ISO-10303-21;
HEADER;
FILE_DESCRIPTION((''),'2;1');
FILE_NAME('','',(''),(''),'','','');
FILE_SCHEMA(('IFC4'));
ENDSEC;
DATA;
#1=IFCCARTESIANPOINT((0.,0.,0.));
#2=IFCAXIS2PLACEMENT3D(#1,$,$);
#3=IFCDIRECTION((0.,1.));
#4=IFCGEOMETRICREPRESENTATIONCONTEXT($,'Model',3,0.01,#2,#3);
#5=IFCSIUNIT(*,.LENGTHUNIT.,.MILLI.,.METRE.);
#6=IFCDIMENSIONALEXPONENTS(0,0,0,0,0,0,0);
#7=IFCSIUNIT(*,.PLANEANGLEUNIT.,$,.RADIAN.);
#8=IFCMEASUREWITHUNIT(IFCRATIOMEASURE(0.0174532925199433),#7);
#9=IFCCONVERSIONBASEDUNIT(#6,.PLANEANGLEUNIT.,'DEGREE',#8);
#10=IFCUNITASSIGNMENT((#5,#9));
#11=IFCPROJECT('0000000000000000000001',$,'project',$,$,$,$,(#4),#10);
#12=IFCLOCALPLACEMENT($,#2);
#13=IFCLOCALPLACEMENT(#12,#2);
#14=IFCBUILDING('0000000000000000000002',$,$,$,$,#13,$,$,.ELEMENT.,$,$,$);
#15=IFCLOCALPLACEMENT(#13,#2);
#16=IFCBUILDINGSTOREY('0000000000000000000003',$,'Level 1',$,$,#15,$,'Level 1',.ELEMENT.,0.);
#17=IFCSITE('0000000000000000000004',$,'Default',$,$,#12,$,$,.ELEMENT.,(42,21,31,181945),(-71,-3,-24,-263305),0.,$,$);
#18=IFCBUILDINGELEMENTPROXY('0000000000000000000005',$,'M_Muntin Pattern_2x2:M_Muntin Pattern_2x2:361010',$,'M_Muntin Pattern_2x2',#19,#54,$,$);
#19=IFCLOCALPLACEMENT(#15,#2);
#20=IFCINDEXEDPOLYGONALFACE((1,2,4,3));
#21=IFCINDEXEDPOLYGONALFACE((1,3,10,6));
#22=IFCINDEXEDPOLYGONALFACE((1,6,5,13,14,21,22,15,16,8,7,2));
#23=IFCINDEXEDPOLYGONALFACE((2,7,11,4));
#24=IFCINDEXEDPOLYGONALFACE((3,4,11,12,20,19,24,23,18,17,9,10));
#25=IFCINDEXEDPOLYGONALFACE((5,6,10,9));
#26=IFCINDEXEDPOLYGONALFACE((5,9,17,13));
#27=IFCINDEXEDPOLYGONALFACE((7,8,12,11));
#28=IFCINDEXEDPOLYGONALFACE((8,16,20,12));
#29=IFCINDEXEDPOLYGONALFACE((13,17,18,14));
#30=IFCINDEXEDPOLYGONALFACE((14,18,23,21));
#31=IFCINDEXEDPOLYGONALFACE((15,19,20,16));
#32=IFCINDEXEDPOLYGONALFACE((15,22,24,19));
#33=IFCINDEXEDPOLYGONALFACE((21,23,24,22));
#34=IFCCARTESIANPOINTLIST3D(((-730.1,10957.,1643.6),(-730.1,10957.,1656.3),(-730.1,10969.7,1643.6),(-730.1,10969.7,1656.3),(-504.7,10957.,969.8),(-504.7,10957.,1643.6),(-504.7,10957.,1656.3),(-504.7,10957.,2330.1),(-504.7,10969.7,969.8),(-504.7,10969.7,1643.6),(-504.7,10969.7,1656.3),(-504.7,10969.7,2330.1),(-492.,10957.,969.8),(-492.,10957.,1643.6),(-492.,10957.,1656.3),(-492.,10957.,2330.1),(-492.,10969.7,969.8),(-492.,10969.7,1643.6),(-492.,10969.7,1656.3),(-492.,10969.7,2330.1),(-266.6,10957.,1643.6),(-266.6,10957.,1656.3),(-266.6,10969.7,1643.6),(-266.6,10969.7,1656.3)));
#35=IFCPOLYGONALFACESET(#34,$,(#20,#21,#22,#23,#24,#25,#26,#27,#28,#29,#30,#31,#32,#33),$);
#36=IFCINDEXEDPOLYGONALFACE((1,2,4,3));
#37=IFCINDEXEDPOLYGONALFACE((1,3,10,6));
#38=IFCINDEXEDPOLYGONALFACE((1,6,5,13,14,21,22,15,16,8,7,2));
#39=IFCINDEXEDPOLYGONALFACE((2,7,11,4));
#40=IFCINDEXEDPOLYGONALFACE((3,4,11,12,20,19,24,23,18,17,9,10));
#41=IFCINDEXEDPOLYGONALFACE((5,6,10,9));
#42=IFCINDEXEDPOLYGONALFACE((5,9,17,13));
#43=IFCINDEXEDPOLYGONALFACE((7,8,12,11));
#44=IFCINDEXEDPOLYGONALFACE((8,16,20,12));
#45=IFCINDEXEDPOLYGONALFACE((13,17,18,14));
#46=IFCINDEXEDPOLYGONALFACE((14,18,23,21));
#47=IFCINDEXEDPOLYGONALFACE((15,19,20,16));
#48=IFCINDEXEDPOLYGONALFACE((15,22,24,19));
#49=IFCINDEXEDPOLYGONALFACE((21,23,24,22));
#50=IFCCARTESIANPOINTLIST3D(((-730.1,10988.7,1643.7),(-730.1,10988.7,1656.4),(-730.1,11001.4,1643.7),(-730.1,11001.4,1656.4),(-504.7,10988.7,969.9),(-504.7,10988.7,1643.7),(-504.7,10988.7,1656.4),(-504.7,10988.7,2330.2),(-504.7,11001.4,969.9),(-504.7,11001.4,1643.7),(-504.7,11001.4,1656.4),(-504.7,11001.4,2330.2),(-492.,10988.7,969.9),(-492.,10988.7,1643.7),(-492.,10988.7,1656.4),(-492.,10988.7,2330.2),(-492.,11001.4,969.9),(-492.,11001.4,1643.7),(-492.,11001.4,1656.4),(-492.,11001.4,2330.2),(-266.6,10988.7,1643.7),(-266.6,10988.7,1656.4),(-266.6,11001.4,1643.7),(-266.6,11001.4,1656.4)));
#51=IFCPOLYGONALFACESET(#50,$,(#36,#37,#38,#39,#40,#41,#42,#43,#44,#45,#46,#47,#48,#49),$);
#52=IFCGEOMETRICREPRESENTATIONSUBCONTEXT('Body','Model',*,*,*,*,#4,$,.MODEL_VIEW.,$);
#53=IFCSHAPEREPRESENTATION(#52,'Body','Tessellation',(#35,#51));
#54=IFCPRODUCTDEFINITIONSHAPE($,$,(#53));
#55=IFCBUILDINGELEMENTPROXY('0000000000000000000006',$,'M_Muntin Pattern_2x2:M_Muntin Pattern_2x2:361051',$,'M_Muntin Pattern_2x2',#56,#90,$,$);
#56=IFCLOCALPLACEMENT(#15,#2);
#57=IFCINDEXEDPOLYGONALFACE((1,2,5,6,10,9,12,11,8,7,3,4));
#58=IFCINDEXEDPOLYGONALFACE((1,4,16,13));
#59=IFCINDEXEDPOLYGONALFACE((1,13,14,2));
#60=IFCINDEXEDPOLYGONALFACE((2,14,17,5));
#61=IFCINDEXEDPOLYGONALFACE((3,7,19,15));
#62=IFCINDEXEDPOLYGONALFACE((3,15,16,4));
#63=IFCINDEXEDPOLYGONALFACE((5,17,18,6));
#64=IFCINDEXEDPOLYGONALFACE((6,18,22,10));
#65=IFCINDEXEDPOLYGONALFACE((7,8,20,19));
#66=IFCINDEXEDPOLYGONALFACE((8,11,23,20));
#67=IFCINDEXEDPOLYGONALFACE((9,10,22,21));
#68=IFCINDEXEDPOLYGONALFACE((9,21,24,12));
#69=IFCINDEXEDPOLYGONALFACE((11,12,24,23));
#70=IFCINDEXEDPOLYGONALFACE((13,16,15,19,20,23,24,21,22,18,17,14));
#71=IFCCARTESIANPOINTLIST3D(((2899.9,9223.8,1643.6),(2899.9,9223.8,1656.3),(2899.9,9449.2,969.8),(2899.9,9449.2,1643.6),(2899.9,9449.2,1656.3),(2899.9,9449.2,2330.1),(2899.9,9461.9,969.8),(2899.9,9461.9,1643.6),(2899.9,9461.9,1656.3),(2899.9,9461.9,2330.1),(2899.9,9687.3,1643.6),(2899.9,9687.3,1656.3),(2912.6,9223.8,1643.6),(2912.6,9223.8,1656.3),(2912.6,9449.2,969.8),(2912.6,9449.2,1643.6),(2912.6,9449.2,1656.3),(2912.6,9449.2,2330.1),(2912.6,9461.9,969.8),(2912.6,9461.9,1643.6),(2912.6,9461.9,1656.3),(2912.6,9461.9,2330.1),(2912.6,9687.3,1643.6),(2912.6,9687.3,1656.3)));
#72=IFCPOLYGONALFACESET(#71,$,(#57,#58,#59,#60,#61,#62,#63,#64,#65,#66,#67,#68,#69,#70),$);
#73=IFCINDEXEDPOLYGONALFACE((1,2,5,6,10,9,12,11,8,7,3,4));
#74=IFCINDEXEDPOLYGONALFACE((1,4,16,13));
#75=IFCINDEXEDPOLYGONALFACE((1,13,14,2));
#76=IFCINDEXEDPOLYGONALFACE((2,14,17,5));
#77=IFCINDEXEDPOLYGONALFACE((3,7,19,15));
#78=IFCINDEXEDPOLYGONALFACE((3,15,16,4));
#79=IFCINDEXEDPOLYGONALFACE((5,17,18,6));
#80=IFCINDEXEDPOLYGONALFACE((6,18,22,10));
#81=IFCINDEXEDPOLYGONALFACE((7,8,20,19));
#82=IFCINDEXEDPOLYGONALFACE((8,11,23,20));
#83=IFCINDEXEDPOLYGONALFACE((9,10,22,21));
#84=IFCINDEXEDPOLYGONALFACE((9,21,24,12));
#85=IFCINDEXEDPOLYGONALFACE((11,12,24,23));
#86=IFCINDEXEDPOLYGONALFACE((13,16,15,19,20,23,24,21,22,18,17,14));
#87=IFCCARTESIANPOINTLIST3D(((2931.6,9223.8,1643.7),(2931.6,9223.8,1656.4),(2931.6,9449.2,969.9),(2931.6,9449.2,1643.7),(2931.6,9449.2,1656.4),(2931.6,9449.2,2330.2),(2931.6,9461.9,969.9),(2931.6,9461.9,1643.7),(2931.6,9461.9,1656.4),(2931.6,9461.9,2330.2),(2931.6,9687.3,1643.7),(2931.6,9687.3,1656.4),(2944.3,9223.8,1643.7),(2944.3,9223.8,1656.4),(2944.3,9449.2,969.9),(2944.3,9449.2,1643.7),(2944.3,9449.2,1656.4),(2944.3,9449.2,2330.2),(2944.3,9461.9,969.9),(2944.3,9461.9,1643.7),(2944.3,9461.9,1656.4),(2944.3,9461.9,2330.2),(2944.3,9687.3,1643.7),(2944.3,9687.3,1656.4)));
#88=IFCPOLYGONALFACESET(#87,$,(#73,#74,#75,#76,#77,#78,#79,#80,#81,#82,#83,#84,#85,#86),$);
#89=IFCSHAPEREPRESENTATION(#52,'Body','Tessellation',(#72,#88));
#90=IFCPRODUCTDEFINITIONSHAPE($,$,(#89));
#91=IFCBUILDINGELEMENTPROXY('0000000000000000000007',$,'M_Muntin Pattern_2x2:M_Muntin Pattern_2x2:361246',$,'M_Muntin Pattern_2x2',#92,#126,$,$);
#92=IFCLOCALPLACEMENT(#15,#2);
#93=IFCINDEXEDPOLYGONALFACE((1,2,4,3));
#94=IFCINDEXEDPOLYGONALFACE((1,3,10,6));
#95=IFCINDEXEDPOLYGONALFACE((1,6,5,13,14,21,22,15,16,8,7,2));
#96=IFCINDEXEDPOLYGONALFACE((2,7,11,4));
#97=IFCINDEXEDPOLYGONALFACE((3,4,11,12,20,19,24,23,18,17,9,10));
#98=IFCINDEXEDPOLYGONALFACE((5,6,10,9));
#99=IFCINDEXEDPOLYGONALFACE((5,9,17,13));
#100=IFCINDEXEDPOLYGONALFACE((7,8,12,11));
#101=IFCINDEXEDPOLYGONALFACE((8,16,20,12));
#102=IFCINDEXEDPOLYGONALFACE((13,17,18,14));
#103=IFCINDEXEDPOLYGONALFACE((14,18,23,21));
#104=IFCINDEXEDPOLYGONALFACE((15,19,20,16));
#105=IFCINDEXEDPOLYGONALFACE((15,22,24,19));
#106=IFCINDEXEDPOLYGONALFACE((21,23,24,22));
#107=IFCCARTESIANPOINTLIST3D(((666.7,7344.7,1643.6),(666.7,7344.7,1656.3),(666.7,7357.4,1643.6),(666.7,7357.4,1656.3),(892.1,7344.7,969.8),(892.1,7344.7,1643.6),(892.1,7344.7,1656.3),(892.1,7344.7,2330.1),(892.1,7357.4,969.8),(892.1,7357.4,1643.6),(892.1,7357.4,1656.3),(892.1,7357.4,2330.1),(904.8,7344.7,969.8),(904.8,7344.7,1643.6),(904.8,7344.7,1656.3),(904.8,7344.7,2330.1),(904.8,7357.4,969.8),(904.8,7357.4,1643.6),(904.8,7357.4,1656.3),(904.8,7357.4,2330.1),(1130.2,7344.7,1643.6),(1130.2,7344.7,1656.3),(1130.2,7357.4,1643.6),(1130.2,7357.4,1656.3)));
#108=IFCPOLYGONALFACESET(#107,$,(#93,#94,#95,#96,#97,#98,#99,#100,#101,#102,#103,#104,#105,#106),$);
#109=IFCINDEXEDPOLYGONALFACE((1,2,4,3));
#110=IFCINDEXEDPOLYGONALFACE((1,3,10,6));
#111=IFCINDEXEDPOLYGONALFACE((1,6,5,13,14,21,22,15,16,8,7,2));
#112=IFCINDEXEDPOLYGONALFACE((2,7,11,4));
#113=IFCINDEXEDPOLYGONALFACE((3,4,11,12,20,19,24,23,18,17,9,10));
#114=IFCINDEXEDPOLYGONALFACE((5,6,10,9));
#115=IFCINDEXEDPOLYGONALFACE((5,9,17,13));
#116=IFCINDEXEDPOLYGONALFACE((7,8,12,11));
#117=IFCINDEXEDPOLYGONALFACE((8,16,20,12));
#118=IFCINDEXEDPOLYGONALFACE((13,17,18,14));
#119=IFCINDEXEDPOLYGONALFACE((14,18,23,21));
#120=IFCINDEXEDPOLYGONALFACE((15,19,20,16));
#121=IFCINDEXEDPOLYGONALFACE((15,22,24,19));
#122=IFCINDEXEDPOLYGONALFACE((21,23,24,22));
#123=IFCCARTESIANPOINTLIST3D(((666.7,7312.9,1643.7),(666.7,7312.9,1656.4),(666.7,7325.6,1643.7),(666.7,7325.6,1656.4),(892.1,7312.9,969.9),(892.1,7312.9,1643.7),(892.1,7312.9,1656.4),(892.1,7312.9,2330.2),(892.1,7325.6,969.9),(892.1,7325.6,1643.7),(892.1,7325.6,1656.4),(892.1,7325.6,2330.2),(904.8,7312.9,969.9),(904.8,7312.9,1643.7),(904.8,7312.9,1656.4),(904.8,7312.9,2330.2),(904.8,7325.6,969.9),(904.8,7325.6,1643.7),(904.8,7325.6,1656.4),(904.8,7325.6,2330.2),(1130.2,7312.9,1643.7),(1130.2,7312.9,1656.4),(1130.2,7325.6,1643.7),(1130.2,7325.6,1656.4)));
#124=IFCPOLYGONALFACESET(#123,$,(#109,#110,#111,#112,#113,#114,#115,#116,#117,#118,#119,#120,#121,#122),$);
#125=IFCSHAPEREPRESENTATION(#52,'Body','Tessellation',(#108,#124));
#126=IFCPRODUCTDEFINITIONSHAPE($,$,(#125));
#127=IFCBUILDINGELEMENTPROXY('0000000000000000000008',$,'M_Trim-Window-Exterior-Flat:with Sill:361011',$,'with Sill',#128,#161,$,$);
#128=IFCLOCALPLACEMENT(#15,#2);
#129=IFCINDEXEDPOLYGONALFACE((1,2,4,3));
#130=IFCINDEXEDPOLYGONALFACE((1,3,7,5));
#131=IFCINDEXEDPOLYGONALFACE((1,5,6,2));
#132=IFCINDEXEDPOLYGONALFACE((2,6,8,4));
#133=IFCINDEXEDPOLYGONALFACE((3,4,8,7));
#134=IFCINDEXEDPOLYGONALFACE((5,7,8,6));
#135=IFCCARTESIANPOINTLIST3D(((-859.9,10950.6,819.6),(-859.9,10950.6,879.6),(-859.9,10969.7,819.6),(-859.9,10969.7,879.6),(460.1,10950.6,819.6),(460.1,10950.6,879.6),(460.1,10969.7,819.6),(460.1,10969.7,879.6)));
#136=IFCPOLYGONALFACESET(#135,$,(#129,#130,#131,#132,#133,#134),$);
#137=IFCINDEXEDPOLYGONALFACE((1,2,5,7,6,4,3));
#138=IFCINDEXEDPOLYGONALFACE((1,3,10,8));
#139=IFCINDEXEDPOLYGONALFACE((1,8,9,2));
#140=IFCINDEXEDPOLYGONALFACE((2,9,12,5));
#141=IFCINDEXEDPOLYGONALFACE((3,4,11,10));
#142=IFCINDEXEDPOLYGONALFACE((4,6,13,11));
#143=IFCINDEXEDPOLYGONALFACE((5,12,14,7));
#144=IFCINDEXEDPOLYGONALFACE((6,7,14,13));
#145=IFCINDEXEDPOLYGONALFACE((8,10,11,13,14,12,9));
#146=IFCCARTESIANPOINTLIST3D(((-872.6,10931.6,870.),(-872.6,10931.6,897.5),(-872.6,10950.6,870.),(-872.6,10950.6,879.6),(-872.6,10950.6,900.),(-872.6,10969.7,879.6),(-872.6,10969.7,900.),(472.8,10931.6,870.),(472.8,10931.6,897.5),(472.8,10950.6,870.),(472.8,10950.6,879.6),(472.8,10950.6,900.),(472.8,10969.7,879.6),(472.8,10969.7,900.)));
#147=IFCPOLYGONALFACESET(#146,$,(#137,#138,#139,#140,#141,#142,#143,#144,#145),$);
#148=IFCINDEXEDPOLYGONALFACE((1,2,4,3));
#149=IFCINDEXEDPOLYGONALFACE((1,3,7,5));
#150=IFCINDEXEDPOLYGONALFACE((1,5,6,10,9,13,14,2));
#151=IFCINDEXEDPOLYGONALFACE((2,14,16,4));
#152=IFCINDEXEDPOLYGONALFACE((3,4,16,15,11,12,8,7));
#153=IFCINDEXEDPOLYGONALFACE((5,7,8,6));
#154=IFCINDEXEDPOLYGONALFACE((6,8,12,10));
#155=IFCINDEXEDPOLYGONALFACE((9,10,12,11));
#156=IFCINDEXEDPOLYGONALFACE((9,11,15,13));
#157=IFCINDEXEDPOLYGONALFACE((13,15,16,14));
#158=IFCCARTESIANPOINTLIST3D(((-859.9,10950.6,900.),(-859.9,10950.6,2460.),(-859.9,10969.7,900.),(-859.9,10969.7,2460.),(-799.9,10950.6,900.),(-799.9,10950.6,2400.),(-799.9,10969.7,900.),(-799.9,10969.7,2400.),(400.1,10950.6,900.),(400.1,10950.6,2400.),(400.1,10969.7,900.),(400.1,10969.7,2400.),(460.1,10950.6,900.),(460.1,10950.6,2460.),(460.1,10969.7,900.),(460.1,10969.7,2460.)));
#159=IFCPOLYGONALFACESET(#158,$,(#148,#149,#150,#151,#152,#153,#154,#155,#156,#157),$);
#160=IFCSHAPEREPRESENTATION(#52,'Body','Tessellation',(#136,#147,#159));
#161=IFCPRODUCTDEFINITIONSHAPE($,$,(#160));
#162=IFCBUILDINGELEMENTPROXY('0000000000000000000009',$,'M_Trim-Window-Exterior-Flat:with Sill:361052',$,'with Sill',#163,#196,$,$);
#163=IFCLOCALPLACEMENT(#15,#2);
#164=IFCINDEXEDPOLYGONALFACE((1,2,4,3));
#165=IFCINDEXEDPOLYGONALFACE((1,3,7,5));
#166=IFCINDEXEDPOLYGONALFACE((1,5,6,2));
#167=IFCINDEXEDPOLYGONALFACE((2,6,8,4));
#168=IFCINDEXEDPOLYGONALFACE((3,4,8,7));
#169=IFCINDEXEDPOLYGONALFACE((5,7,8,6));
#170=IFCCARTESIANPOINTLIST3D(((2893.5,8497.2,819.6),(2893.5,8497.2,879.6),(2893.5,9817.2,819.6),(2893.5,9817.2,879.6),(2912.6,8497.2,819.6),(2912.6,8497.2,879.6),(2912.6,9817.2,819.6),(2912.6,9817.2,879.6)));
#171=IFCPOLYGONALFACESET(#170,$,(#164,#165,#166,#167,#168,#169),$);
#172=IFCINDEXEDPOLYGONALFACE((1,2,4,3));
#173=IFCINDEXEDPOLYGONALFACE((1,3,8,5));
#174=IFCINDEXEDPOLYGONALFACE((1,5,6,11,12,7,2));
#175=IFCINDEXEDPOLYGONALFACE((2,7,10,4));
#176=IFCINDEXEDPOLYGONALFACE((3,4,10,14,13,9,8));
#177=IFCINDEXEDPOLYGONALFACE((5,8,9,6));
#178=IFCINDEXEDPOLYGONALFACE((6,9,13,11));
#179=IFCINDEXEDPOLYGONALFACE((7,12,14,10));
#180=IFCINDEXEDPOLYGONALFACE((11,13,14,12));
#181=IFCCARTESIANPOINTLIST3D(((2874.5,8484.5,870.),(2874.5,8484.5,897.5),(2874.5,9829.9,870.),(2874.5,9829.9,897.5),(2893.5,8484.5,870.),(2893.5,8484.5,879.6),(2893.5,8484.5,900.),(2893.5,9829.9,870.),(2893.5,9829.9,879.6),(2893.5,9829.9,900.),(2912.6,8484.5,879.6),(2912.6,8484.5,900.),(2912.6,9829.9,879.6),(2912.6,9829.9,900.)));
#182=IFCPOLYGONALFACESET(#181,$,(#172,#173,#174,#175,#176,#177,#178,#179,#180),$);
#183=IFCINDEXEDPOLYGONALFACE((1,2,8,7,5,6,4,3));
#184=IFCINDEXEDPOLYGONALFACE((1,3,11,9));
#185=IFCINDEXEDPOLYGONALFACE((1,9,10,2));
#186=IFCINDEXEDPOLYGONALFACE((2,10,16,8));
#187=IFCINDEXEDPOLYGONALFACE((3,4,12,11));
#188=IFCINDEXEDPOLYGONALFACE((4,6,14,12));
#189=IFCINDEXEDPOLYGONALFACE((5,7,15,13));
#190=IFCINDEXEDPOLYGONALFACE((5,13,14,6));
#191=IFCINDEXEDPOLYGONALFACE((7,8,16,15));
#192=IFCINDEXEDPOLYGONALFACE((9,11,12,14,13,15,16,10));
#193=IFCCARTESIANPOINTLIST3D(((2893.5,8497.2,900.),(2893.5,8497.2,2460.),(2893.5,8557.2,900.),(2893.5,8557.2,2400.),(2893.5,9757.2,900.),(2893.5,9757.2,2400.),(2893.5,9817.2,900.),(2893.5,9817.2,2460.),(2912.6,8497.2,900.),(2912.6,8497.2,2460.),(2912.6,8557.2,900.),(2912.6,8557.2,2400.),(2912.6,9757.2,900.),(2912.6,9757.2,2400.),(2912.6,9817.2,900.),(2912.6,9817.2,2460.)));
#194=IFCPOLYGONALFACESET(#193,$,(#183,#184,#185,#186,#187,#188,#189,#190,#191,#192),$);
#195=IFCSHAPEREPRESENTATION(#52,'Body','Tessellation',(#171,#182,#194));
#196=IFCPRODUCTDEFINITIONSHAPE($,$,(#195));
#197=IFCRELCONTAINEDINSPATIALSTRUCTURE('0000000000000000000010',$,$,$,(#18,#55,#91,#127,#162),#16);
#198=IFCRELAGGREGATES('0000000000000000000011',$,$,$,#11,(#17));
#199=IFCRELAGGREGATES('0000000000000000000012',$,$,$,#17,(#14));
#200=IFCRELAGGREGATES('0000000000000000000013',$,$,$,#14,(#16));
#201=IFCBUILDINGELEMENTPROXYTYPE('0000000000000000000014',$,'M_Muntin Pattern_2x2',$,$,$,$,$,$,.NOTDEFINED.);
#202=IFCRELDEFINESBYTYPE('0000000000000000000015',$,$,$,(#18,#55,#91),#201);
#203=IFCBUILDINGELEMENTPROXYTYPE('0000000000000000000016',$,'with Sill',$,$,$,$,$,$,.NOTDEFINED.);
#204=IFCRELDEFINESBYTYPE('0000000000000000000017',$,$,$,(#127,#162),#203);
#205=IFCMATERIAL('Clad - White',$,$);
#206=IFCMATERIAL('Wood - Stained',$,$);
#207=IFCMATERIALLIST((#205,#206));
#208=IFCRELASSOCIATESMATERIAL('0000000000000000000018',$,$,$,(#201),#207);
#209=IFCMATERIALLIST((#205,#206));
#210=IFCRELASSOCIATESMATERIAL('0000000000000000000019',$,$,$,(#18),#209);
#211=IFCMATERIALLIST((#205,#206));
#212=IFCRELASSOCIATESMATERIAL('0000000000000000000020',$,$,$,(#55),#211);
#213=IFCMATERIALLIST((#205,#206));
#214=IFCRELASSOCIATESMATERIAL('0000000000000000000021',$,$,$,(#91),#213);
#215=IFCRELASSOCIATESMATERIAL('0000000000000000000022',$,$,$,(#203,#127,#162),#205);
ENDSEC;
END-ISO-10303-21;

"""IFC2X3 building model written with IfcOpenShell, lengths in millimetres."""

from ifc_helpers import new_model, entity, si_unit, converted_unit, direction, frame, frame_2d, origin, place, context, subcontext, project, spatial, polyline, rectangle, outline, extrude, source, transform, mapped, material, material_list, type_object, type_shapes, element, save


model = new_model("IFC2X3")

# Units and contexts
model_context = context("Model", 3, precision=0.01, world=origin(), true_north=direction((0.0, 1.0)))
body_context = subcontext(model_context, "Body", "Model", "MODEL_VIEW")
ifc_project = project(units=[si_unit("LENGTHUNIT", "METRE", prefix="MILLI"), converted_unit("PLANEANGLEUNIT", "DEGREE", entity("IfcRatioMeasure", 0.0174532925199433), si_unit("PLANEANGLEUNIT", "RADIAN"), dimensions=[0, 0, 0, 0, 0, 0, 0])], contexts=[model_context])

# Site, building, storey
site_placement = place(None, origin())
site = spatial("IfcSite", under=ifc_project, at=site_placement, Name="Default", CompositionType="ELEMENT", RefLatitude=(42, 21, 31, 181945), RefLongitude=(-71, -3, -24, -263305), RefElevation=0.0)
building_placement = place(site_placement, origin())
building = spatial("IfcBuilding", under=site, at=building_placement, CompositionType="ELEMENT")
storey_placement = place(building_placement, origin())
storey = spatial("IfcBuildingStorey", under=building, at=storey_placement, Name="Level 1", LongName="Level 1", CompositionType="ELEMENT", Elevation=0.0)

# Building element proxies
ifc_material_1 = material(Name="Clad - White")
ifc_material_2 = material(Name="Wood - Stained")
ifc_material_list_1 = material_list([ifc_material_1, ifc_material_2])
ifc_material_list_2 = material_list([ifc_material_1, ifc_material_2])
building_element_proxy_type_1 = type_object("IfcBuildingElementProxyType", Name="M_Muntin Pattern_2x2", PredefinedType="NOTDEFINED", material=ifc_material_list_2)
shared_shape_1 = source(origin(), body_context, "Body", "SweptSolid", [
    extrude(outline(polyline([(6.4, -6.4), (680.1, -6.4), (680.1, 6.3), (6.4, 6.3), (6.4, 231.7), (-6.3, 231.7), (-6.3, 6.3), (-680.2, 6.3), (-680.2, -6.4), (-6.3, -6.4), (-6.3, -231.7), (6.4, -231.7), (6.4, -6.4)])), frame((0.0, -22.2, 680.1), z_axis=(0.0, 1.0, 0.0), x_axis=(0.0, 0.0, 1.0)), (0.0, 0.0, 1.0), 12.7),
    extrude(outline(polyline([(6.4, -6.4), (680.1, -6.4), (680.1, 6.3), (6.4, 6.3), (6.4, 231.7), (-6.3, 231.7), (-6.3, 6.3), (-680.2, 6.3), (-680.2, -6.4), (-6.3, -6.4), (-6.3, -231.7), (6.4, -231.7), (6.4, -6.4)])), frame((0.0, 9.5, 680.2), z_axis=(0.0, 1.0, 0.0), x_axis=(0.0, 0.0, 1.0)), (0.0, 0.0, 1.0), 12.7),
])
type_shapes(building_element_proxy_type_1, [shared_shape_1])
proxy_1_placement = place(storey_placement, frame((-498.4, 10979.2, 969.9)))
element("IfcBuildingElementProxy", 1, at=proxy_1_placement, inside=storey, type_object=building_element_proxy_type_1, material=ifc_material_list_1, Name="M_Muntin Pattern_2x2:M_Muntin Pattern_2x2:361010", ObjectType="M_Muntin Pattern_2x2", context=body_context, shape_type="MappedRepresentation", body=[
    mapped(shared_shape_1, transform((0.0, 0.0, 0.0), scale=1.0)),
])
ifc_material_list_3 = material_list([ifc_material_1, ifc_material_2])
proxy_2_placement = place(storey_placement, frame((2922.1, 9455.6, 969.9), z_axis=(0.0, 0.0, 1.0), x_axis=(0.0, -1.0, 0.0)))
element("IfcBuildingElementProxy", 2, at=proxy_2_placement, inside=storey, type_object=building_element_proxy_type_1, material=ifc_material_list_3, Name="M_Muntin Pattern_2x2:M_Muntin Pattern_2x2:361051", ObjectType="M_Muntin Pattern_2x2", context=body_context, shape_type="MappedRepresentation", body=[
    mapped(shared_shape_1, transform((0.0, 0.0, 0.0), scale=1.0)),
])
ifc_material_list_4 = material_list([ifc_material_1, ifc_material_2])
proxy_3_placement = place(storey_placement, frame((898.5, 7335.1, 969.9), z_axis=(0.0, 0.0, 1.0), x_axis=(-1.0, 0.0, 0.0)))
element("IfcBuildingElementProxy", 3, at=proxy_3_placement, inside=storey, type_object=building_element_proxy_type_1, material=ifc_material_list_4, Name="M_Muntin Pattern_2x2:M_Muntin Pattern_2x2:361246", ObjectType="M_Muntin Pattern_2x2", context=body_context, shape_type="MappedRepresentation", body=[
    mapped(shared_shape_1, transform((0.0, 0.0, 0.0), scale=1.0)),
])
building_element_proxy_type_2 = type_object("IfcBuildingElementProxyType", Name="with Sill", PredefinedType="NOTDEFINED", material=ifc_material_1)
shared_shape_2 = source(origin(), body_context, "Body", "SweptSolid", [
    extrude(rectangle(XDim=1320.0, YDim=60.0, at=frame_2d((0.0, 0.0), x_axis=(1.0, 0.0))), frame((0.0, -1550.4, 0.0), z_axis=(0.0, 0.0, 1.0), x_axis=(-1.0, 0.0, 0.0)), (0.0, 0.0, 1.0), 19.1),
    extrude(outline(polyline([(-19.0, -15.2), (0.0, -15.2), (0.0, -5.7), (19.0, -5.7), (19.0, 14.8), (0.0, 14.8), (-19.0, 12.3), (-19.0, -15.2)])), frame((-672.7, -1514.8, 19.0), z_axis=(1.0, 0.0, 0.0), x_axis=(0.0, 0.0, -1.0)), (0.0, 0.0, 1.0), 1345.4),
    extrude(outline(polyline([(-795.0, -660.0), (765.0, -660.0), (765.0, -600.0), (-735.0, -600.0), (-735.0, 600.0), (765.0, 600.0), (765.0, 660.0), (-795.0, 660.0), (-795.0, -660.0)])), frame((0.0, -735.0, 0.0), z_axis=(0.0, 0.0, 1.0), x_axis=(0.0, -1.0, 0.0)), (0.0, 0.0, 1.0), 19.1),
])
type_shapes(building_element_proxy_type_2, [shared_shape_2])
for number, where, z_axis, x_axis, name in (
    (4, (-199.9, 10969.7, 2400.0), (0.0, -1.0, 0.0), (1.0, 0.0, 0.0), "M_Trim-Window-Exterior-Flat:with Sill:361011"),
    (5, (2912.6, 9157.2, 2400.0), (-1.0, 0.0, 0.0), (0.0, -1.0, 0.0), "M_Trim-Window-Exterior-Flat:with Sill:361052"),
):
    element("IfcBuildingElementProxy", number, at=place(storey_placement, frame(where, z_axis=z_axis, x_axis=x_axis)), inside=storey, type_object=building_element_proxy_type_2, material=ifc_material_1, Name=name, ObjectType="with Sill", context=body_context, shape_type="MappedRepresentation", body=[
        mapped(shared_shape_2, transform((0.0, 0.0, 0.0), scale=1.0)),
    ])

save(model, "model.ifc")
